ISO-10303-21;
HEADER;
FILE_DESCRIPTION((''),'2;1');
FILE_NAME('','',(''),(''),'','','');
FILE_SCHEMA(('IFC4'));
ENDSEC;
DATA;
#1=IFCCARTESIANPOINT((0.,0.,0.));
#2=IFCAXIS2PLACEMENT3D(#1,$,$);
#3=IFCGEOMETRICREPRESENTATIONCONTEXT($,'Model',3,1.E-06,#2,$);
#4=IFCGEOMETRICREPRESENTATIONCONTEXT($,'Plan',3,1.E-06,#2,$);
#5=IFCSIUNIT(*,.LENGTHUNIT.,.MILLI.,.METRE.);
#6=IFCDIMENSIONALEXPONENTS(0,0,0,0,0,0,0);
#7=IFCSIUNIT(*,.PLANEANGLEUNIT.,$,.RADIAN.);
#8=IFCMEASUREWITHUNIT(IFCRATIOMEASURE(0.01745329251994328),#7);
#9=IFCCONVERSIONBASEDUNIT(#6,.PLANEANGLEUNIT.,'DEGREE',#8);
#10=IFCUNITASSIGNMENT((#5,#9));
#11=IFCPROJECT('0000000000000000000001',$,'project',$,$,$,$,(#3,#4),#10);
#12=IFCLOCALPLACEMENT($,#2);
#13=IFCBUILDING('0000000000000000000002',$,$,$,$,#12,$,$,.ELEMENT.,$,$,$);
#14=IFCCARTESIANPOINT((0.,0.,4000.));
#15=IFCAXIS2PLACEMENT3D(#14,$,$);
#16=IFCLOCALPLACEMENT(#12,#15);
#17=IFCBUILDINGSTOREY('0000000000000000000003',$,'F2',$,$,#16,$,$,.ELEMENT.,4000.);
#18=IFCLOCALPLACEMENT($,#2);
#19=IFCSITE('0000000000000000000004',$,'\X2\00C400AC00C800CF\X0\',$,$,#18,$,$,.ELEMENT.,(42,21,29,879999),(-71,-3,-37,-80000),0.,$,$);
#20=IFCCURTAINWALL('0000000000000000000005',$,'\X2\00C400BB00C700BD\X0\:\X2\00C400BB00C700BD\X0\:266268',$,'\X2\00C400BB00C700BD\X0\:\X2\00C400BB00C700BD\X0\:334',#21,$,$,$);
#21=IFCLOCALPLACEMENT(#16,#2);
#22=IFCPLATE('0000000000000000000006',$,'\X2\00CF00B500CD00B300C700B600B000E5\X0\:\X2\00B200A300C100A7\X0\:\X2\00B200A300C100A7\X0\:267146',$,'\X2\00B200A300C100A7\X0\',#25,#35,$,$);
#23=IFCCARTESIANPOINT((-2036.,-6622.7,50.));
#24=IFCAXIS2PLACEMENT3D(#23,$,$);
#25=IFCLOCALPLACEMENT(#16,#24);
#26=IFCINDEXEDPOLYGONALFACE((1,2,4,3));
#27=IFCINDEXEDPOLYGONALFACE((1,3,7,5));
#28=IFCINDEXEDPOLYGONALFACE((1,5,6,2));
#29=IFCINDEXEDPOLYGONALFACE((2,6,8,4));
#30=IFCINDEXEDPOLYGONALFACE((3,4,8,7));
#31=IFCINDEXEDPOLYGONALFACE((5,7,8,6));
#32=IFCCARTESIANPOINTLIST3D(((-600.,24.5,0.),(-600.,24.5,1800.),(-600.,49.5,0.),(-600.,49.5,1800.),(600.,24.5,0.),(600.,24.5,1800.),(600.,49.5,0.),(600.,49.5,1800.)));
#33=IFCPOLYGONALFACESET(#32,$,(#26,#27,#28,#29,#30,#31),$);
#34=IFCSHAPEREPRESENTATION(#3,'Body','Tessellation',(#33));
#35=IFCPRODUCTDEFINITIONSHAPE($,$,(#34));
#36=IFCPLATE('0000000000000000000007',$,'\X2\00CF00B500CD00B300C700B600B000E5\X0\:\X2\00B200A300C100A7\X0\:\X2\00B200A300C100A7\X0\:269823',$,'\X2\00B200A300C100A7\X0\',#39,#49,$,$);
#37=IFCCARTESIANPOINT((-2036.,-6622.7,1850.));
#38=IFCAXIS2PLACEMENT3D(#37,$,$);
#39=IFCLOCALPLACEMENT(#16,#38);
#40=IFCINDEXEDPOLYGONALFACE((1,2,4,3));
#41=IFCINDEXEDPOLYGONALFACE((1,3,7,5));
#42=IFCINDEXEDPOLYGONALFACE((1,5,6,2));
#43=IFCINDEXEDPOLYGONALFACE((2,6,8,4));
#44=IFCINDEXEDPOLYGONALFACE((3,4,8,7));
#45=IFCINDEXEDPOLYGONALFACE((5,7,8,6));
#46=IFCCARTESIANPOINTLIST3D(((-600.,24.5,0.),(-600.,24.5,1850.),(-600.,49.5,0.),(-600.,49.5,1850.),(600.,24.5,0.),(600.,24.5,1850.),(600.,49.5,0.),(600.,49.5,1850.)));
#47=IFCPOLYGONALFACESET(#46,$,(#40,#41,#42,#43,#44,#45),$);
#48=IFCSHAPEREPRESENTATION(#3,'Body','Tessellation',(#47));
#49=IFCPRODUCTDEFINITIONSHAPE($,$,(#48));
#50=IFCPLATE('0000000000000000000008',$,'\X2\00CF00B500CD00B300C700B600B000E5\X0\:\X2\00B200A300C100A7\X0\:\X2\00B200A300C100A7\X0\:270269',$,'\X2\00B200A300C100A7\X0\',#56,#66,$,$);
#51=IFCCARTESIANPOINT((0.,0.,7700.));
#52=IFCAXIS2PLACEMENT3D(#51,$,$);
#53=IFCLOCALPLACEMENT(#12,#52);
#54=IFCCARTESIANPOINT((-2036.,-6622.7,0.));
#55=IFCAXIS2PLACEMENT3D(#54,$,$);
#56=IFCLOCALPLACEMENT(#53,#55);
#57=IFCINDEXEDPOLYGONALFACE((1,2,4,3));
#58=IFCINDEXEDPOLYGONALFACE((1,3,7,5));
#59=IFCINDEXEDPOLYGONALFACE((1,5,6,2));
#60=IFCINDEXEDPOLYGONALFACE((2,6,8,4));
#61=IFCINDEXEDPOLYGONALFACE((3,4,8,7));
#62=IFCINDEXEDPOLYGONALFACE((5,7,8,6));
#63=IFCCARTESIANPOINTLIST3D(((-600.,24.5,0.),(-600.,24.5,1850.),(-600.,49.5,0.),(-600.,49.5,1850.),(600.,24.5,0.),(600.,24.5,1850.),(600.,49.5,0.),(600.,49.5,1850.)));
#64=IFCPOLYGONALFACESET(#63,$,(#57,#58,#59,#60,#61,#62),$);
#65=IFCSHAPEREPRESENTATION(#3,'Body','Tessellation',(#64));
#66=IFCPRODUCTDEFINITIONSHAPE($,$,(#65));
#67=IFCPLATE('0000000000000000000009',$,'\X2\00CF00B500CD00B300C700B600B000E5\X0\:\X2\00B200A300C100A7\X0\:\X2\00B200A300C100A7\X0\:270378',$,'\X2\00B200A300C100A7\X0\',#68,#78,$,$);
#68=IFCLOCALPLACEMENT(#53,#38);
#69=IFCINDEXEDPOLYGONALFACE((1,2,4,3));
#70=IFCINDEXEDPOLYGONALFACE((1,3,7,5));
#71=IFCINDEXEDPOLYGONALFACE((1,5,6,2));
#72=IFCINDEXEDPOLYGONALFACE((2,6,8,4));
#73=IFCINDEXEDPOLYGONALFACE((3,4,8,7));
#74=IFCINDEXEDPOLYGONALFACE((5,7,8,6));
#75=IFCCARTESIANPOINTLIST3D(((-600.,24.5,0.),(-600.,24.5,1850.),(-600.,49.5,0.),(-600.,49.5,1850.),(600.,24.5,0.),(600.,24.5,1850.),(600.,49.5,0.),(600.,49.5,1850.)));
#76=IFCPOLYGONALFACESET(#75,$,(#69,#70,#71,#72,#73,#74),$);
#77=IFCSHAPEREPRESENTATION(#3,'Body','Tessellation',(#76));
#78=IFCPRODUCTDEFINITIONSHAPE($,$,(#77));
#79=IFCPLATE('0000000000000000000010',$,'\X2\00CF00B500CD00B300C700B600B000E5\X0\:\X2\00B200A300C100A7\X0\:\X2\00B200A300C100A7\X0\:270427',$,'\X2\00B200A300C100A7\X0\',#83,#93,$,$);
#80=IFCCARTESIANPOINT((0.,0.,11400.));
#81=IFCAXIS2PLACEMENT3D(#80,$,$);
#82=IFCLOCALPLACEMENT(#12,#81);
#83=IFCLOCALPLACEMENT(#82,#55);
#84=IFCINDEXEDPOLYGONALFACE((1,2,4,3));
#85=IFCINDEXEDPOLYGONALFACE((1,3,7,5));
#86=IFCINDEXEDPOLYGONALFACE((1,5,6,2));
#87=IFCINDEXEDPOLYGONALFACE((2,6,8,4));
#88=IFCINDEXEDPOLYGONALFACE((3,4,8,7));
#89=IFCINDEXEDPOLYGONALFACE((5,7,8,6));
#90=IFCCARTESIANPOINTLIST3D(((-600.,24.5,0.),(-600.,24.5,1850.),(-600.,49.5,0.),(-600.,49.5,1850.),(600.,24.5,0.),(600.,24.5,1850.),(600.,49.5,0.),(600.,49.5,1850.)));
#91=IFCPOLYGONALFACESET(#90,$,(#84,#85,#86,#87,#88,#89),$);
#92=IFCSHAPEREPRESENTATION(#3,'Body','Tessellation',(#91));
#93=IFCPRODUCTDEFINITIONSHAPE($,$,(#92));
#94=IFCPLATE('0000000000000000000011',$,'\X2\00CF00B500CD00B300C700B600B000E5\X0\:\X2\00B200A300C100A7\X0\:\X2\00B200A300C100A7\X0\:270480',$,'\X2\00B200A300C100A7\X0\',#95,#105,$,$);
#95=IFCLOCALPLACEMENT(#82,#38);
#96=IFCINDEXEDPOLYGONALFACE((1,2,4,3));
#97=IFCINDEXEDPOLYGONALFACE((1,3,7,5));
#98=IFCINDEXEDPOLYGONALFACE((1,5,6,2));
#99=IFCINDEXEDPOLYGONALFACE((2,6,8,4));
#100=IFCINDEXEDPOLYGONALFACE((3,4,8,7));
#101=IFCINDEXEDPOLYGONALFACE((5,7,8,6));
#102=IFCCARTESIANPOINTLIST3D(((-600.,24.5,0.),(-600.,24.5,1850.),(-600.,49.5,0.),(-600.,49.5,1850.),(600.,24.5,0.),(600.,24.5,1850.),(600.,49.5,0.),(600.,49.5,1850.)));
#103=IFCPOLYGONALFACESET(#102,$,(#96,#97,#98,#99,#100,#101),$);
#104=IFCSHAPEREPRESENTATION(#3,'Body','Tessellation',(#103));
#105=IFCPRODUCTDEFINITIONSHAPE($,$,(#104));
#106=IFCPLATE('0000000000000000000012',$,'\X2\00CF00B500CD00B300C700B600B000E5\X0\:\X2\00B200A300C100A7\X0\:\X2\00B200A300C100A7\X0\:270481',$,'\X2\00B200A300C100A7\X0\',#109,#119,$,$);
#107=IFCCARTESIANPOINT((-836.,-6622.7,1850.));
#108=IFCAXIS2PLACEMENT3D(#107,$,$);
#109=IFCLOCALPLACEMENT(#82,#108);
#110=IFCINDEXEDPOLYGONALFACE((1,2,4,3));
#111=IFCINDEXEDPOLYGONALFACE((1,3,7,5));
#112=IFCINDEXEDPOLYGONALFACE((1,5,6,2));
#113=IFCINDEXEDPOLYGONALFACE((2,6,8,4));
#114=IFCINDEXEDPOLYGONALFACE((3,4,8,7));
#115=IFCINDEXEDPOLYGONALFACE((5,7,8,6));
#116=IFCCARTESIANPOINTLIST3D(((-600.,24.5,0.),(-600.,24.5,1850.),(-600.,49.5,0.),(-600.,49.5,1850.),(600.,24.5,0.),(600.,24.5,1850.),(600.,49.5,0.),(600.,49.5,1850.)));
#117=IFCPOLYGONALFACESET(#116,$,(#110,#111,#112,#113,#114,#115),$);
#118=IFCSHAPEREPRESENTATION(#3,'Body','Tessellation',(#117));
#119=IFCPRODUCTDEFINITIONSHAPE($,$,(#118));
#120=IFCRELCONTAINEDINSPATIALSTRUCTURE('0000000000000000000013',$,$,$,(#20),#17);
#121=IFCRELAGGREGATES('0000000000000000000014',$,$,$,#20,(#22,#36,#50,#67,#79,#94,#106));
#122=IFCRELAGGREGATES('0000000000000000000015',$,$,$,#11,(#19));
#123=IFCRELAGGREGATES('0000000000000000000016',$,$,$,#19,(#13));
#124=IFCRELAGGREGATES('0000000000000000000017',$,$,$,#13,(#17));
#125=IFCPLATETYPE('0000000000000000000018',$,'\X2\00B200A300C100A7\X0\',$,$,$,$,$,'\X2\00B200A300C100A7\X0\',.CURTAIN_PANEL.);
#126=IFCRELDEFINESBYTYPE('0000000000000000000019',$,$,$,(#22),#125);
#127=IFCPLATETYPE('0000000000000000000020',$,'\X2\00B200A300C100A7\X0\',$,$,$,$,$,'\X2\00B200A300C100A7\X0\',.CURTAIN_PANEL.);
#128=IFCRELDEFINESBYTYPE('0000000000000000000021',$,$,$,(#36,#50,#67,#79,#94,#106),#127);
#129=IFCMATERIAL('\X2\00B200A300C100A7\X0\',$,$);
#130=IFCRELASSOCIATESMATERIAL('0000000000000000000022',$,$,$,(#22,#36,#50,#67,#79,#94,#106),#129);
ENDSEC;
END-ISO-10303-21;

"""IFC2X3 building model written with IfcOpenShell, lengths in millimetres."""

from ifc_helpers import new_model, entity, si_unit, converted_unit, frame, origin, origin_2d_with_axis, place, context, project, spatial, rectangle, extrude, source, transform, mapped, material, type_object, type_shapes, element, aggregate, save


model = new_model("IFC2X3")

# Units and contexts
model_context = context("Model", 3, precision=1e-06, world=origin())
plan_context = context("Plan", 3, precision=1e-06, world=origin())
ifc_project = project(units=[si_unit("LENGTHUNIT", "METRE", prefix="MILLI"), converted_unit("PLANEANGLEUNIT", "DEGREE", entity("IfcRatioMeasure", 0.01745329251994328), si_unit("PLANEANGLEUNIT", "RADIAN"), dimensions=[0, 0, 0, 0, 0, 0, 0])], contexts=[model_context, plan_context])

# Site, building, storey
site_placement = place(None, origin())
site = spatial("IfcSite", under=ifc_project, at=site_placement, Name="Ä¬ÈÏ", CompositionType="ELEMENT", RefLatitude=(42, 21, 29, 879999), RefLongitude=(-71, -3, -37, -80000), RefElevation=0.0)
building_placement = place(None, origin())
building = spatial("IfcBuilding", under=site, at=building_placement, CompositionType="ELEMENT")
storey_placement = place(building_placement, frame((0.0, 0.0, 4000.0)))
storey = spatial("IfcBuildingStorey", under=building, at=storey_placement, Name="F2", CompositionType="ELEMENT", Elevation=4000.0)

# Curtain wall
curtain_wall_placement = place(storey_placement, origin())
curtain_wall = element("IfcCurtainWall", 1, at=curtain_wall_placement, inside=storey, Name="Ä»Ç½:Ä»Ç½:266268", ObjectType="Ä»Ç½:Ä»Ç½:334")
placement_1 = place(building_placement, frame((0.0, 0.0, 11400.0)))
placement_2 = place(building_placement, frame((0.0, 0.0, 7700.0)))

# Plates
ifc_material_1 = material(Name="²£Á§")
plate_type_1 = type_object("IfcPlateType", Name="²£Á§", ElementType="²£Á§", PredefinedType="CURTAIN_PANEL")
shared_shape_1 = source(origin(), model_context, "Body", "SweptSolid", [
    extrude(rectangle(XDim=25.0, YDim=1200.0, at=origin_2d_with_axis()), frame((0.0, 37.0, 0.0), z_axis=(0.0, 0.0, 1.0), x_axis=(0.0, 1.0, 0.0)), (0.0, 0.0, 1.0), 1800.0),
])
type_shapes(plate_type_1, [shared_shape_1])
plate_1_placement = place(storey_placement, frame((-2036.0, -6622.7, 50.0)))
plate_1 = element("IfcPlate", 2, at=plate_1_placement, type_object=plate_type_1, material=ifc_material_1, Name="ÏµÍ³Ç¶°å:²£Á§:²£Á§:267146", ObjectType="²£Á§", context=model_context, shape_type="MappedRepresentation", body=[
    mapped(shared_shape_1, transform((0.0, 0.0, 0.0), scale=1.0)),
])
plate_type_2 = type_object("IfcPlateType", Name="²£Á§", ElementType="²£Á§", PredefinedType="CURTAIN_PANEL")
shared_shape_2 = source(origin(), model_context, "Body", "SweptSolid", [
    extrude(rectangle(XDim=25.0, YDim=1200.0, at=origin_2d_with_axis()), frame((0.0, 37.0, 0.0), z_axis=(0.0, 0.0, 1.0), x_axis=(0.0, 1.0, 0.0)), (0.0, 0.0, 1.0), 1850.0),
])
type_shapes(plate_type_2, [shared_shape_2])
plate_2_placement = place(storey_placement, frame((-2036.0, -6622.7, 1850.0)))
plate_2 = element("IfcPlate", 3, at=plate_2_placement, type_object=plate_type_2, material=ifc_material_1, Name="ÏµÍ³Ç¶°å:²£Á§:²£Á§:269823", ObjectType="²£Á§", context=model_context, shape_type="MappedRepresentation", body=[
    mapped(shared_shape_2, transform((0.0, 0.0, 0.0), scale=1.0)),
])
plate_3_placement = place(placement_2, frame((-2036.0, -6622.7, 0.0)))
plate_3 = element("IfcPlate", 4, at=plate_3_placement, type_object=plate_type_2, material=ifc_material_1, Name="ÏµÍ³Ç¶°å:²£Á§:²£Á§:270269", ObjectType="²£Á§", context=model_context, shape_type="MappedRepresentation", body=[
    mapped(shared_shape_2, transform((0.0, 0.0, 0.0), scale=1.0)),
])
plate_4_placement = place(placement_2, frame((-2036.0, -6622.7, 1850.0)))
plate_4 = element("IfcPlate", 5, at=plate_4_placement, type_object=plate_type_2, material=ifc_material_1, Name="ÏµÍ³Ç¶°å:²£Á§:²£Á§:270378", ObjectType="²£Á§", context=model_context, shape_type="MappedRepresentation", body=[
    mapped(shared_shape_2, transform((0.0, 0.0, 0.0), scale=1.0)),
])
plate_5_placement = place(placement_1, frame((-2036.0, -6622.7, 0.0)))
plate_5 = element("IfcPlate", 6, at=plate_5_placement, type_object=plate_type_2, material=ifc_material_1, Name="ÏµÍ³Ç¶°å:²£Á§:²£Á§:270427", ObjectType="²£Á§", context=model_context, shape_type="MappedRepresentation", body=[
    mapped(shared_shape_2, transform((0.0, 0.0, 0.0), scale=1.0)),
])
plate_6_placement = place(placement_1, frame((-2036.0, -6622.7, 1850.0)))
plate_6 = element("IfcPlate", 7, at=plate_6_placement, type_object=plate_type_2, material=ifc_material_1, Name="ÏµÍ³Ç¶°å:²£Á§:²£Á§:270480", ObjectType="²£Á§", context=model_context, shape_type="MappedRepresentation", body=[
    mapped(shared_shape_2, transform((0.0, 0.0, 0.0), scale=1.0)),
])
plate_7_placement = place(placement_1, frame((-836.0, -6622.7, 1850.0)))
plate_7 = element("IfcPlate", 8, at=plate_7_placement, type_object=plate_type_2, material=ifc_material_1, Name="ÏµÍ³Ç¶°å:²£Á§:²£Á§:270481", ObjectType="²£Á§", context=model_context, shape_type="MappedRepresentation", body=[
    mapped(shared_shape_2, transform((0.0, 0.0, 0.0), scale=1.0)),
])
aggregate(curtain_wall, [plate_1, plate_2, plate_3, plate_4, plate_5, plate_6, plate_7])

save(model, "model.ifc")
